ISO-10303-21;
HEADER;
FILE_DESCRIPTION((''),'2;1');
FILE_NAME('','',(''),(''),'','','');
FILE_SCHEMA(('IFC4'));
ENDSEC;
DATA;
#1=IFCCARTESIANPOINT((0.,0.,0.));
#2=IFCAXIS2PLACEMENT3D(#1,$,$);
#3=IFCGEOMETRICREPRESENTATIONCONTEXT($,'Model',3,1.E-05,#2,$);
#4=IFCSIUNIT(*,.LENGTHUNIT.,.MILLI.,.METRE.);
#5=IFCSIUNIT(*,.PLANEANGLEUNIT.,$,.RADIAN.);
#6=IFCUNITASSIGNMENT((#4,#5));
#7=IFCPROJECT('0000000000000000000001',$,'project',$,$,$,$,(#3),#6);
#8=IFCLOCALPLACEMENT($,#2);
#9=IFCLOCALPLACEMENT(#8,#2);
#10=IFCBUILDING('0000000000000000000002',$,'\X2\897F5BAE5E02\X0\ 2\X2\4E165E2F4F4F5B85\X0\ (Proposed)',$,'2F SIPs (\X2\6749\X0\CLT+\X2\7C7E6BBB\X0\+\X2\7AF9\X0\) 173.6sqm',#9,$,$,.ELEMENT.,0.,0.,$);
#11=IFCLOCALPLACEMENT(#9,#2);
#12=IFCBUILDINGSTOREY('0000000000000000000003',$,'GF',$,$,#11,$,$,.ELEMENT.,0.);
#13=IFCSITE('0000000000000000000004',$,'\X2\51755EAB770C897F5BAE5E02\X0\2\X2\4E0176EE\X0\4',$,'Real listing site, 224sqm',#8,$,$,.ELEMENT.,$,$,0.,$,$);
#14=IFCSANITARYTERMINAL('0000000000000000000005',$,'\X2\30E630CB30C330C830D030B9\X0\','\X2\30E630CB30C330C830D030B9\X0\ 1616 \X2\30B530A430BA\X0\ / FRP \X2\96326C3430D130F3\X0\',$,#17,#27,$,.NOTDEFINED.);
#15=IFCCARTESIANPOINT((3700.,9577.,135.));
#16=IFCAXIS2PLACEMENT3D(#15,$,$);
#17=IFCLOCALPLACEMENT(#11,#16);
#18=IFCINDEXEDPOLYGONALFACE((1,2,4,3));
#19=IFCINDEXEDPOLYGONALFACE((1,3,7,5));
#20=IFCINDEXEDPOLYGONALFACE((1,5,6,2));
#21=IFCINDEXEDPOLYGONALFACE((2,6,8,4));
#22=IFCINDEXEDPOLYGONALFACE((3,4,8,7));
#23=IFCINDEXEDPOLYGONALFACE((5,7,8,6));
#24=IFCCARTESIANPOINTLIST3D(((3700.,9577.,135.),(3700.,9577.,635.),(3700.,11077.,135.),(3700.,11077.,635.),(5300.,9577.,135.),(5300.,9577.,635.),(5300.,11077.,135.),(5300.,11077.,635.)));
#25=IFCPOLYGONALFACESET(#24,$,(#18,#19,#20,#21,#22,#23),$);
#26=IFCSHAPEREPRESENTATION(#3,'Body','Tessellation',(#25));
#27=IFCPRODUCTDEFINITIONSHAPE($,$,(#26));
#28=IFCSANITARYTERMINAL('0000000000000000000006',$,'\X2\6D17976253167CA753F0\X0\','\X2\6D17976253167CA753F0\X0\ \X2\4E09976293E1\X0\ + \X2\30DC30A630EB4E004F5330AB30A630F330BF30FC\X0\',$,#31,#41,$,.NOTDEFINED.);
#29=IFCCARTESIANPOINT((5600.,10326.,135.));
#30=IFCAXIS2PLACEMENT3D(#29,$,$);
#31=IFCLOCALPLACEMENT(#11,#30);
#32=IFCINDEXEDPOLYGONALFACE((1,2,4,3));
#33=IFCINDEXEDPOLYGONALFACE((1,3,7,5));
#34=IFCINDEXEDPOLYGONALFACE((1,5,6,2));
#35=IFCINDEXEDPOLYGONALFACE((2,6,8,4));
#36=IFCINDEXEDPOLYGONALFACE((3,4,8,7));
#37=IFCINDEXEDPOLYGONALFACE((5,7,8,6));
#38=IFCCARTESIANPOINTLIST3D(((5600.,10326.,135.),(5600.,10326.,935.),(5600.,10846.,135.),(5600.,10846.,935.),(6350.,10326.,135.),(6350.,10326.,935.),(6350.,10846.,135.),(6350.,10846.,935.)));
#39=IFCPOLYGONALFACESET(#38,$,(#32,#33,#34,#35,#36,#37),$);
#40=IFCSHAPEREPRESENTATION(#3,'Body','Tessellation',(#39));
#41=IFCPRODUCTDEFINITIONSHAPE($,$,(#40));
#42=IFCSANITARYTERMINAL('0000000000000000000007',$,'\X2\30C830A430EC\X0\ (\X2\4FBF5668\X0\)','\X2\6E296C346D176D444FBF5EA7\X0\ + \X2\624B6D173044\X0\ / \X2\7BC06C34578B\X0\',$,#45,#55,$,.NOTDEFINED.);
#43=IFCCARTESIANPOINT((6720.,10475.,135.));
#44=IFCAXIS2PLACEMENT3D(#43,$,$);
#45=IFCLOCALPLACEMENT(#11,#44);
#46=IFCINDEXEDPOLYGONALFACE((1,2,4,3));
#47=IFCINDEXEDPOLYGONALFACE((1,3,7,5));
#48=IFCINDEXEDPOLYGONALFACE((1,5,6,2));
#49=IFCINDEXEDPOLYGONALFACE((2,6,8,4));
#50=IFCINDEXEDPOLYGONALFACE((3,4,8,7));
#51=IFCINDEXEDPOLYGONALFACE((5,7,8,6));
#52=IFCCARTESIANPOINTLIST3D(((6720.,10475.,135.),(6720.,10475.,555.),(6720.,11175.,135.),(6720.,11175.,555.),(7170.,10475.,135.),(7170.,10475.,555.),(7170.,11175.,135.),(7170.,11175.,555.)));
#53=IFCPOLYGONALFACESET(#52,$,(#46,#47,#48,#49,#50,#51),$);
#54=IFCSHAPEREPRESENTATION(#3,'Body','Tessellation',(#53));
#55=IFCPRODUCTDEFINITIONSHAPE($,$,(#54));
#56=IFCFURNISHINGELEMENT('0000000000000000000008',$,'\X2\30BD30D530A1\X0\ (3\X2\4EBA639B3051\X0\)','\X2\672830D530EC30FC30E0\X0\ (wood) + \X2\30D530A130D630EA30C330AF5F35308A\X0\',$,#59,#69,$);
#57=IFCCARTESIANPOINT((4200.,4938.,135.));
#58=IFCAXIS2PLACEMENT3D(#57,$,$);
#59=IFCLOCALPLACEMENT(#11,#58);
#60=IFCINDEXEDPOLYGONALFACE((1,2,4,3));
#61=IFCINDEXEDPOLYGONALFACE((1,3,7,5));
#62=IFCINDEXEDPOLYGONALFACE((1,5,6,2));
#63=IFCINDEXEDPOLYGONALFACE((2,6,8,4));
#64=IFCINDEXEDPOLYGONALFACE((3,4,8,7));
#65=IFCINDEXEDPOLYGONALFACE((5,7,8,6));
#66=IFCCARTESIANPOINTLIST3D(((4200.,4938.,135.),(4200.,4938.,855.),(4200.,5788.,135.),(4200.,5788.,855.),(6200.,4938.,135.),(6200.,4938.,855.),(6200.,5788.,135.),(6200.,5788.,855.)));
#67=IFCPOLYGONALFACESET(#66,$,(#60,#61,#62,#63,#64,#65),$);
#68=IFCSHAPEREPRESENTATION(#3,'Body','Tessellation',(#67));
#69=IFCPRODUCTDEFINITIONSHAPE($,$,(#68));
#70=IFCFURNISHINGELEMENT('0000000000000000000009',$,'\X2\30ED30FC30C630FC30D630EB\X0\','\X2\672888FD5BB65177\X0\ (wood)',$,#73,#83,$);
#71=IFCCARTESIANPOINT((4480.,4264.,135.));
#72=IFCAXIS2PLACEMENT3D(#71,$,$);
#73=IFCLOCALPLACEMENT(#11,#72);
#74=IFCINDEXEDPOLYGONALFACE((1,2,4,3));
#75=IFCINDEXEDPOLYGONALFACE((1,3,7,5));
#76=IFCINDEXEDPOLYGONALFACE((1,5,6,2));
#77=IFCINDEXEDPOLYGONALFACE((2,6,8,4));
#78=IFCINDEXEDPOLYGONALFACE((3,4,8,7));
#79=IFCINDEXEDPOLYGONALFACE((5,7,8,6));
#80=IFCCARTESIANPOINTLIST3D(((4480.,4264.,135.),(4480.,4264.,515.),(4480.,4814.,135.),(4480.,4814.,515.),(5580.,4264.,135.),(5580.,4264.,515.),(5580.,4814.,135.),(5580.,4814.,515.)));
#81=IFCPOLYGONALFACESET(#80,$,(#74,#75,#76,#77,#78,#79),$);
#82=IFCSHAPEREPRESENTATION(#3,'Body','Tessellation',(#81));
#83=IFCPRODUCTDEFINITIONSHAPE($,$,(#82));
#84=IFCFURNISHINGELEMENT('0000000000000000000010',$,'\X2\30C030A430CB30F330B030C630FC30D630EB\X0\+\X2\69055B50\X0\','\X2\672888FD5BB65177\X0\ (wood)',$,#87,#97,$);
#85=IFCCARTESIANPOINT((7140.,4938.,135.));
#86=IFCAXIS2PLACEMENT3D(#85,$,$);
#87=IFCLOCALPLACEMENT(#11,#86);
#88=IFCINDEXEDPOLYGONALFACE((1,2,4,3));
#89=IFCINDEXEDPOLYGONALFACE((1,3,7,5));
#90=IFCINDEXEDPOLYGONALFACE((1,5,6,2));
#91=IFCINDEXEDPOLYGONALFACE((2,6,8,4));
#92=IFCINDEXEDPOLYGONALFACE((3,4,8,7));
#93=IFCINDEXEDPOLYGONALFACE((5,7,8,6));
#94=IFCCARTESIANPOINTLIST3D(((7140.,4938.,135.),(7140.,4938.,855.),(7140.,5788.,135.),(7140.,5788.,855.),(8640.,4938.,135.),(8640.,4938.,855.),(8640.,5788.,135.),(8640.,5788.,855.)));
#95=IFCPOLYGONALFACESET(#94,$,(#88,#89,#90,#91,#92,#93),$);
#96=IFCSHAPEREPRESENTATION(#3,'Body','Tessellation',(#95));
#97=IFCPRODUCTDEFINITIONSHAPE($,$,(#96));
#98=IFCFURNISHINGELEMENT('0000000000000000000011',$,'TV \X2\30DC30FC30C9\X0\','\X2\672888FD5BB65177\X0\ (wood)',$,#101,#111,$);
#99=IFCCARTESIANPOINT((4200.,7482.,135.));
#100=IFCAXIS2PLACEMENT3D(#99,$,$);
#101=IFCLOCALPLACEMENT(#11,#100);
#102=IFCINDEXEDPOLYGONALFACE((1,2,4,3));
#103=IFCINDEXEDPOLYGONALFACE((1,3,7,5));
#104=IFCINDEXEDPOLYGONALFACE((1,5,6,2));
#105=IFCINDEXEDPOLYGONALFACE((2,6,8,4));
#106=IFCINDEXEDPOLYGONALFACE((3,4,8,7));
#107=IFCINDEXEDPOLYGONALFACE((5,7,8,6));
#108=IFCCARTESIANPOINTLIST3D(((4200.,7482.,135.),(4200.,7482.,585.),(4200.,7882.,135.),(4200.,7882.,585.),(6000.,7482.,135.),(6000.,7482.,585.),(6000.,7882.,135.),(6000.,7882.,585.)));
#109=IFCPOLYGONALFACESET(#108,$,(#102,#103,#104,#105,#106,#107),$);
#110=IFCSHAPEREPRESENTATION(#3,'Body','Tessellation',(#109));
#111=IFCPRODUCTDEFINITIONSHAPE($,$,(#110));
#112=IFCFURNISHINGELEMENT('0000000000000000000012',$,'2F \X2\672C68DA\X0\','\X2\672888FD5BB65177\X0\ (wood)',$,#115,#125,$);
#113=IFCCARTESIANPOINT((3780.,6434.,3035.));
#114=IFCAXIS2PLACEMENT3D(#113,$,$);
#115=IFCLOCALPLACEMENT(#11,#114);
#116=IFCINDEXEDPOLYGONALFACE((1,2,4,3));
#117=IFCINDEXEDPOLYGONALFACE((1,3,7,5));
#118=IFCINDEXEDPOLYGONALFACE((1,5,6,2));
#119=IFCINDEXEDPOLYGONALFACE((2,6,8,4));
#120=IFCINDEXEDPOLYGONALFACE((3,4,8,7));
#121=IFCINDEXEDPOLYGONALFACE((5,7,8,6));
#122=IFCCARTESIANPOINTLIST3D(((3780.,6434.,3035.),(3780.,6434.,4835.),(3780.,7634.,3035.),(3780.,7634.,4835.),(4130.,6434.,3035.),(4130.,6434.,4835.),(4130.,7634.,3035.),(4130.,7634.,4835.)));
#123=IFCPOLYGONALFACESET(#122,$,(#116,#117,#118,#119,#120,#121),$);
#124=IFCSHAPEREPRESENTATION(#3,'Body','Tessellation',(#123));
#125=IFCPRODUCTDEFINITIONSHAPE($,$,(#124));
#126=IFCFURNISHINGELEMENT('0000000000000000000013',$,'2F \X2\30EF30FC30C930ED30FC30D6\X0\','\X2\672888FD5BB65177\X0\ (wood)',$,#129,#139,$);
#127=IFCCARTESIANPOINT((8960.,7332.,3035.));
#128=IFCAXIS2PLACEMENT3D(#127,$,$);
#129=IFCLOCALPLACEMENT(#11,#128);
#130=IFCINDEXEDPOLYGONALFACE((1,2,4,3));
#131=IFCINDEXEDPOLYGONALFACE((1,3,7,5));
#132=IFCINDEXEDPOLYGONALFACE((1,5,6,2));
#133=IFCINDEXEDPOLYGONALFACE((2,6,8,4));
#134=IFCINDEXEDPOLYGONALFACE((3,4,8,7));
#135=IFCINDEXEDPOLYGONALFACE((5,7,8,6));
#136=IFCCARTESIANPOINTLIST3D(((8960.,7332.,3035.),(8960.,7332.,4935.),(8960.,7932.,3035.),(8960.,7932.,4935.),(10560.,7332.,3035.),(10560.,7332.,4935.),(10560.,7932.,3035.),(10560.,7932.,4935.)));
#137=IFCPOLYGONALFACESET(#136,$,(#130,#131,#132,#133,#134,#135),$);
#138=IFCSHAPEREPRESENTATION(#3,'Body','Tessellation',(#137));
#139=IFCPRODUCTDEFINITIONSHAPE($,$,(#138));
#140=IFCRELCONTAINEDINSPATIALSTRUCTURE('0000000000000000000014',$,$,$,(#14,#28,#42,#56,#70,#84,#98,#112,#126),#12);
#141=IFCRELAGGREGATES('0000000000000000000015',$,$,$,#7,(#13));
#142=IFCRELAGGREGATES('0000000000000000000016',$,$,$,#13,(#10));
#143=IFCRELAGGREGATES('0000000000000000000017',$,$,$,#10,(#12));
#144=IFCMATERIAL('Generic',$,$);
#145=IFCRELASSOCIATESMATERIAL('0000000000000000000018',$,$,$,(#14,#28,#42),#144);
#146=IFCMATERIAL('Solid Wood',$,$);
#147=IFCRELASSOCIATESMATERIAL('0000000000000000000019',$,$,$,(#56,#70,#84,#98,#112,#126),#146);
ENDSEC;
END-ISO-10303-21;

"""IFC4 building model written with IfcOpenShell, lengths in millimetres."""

from ifc_helpers import new_model, si_unit, frame, frame_2d, origin, place, context, project, spatial, rectangle, extrude, material, element, save


model = new_model("IFC4")

# Units and contexts
model_context = context("Model", 3, precision=1e-05, world=origin())
ifc_project = project(units=[si_unit("LENGTHUNIT", "METRE", prefix="MILLI"), si_unit("PLANEANGLEUNIT", "RADIAN")], contexts=[model_context])

# Site, building, storey
site_placement = place(None, origin())
site = spatial("IfcSite", under=ifc_project, at=site_placement, Name="兵庫県西宮市2丁目4", ObjectType="Real listing site, 224sqm", CompositionType="ELEMENT", RefElevation=0.0)
building_placement = place(site_placement, origin())
building = spatial("IfcBuilding", under=site, at=building_placement, Name="西宮市 2世帯住宅 (Proposed)", ObjectType="2F SIPs (杉CLT+籾殻+竹) 173.6sqm", CompositionType="ELEMENT", ElevationOfRefHeight=0.0, ElevationOfTerrain=0.0)
storey_placement = place(building_placement, origin())
storey = spatial("IfcBuildingStorey", under=building, at=storey_placement, Name="GF", CompositionType="ELEMENT", Elevation=0.0)

# Shared definitions
ifc_material_1 = material(Name="Generic")

# Shared definitions
ifc_material_2 = material(Name="Solid Wood")

# Sanitary terminals
sanitary_terminal_1_placement = place(storey_placement, frame((3700.0, 9577.0, 135.0)))
element("IfcSanitaryTerminal", 1, at=sanitary_terminal_1_placement, inside=storey, material=ifc_material_1, Name="ユニットバス", Description="ユニットバス 1616 サイズ / FRP 防水パン", PredefinedType="NOTDEFINED", context=model_context, shape_type="SweptSolid", body=[
    extrude(rectangle(XDim=1600.0, YDim=1500.0, at=frame_2d((800.0, 750.0))), frame((3700.0, 9577.0, 135.0)), (0.0, 0.0, 1.0), 500.0),
])
sanitary_terminal_2_placement = place(storey_placement, frame((5600.0, 10326.0, 135.0)))
element("IfcSanitaryTerminal", 2, at=sanitary_terminal_2_placement, inside=storey, material=ifc_material_1, Name="洗面化粧台", Description="洗面化粧台 三面鏡 + ボウル一体カウンター", PredefinedType="NOTDEFINED", context=model_context, shape_type="SweptSolid", body=[
    extrude(rectangle(XDim=750.0, YDim=520.0, at=frame_2d((375.0, 260.0))), frame((5600.0, 10326.0, 135.0)), (0.0, 0.0, 1.0), 800.0),
])
sanitary_terminal_3_placement = place(storey_placement, frame((6720.0, 10475.0, 135.0)))
element("IfcSanitaryTerminal", 3, at=sanitary_terminal_3_placement, inside=storey, material=ifc_material_1, Name="トイレ (便器)", Description="温水洗浄便座 + 手洗い / 節水型", PredefinedType="NOTDEFINED", context=model_context, shape_type="SweptSolid", body=[
    extrude(rectangle(XDim=450.0, YDim=700.0, at=frame_2d((225.0, 350.0))), frame((6720.0, 10475.0, 135.0)), (0.0, 0.0, 1.0), 420.0),
])

# Furnishing elements
furnishing_1_placement = place(storey_placement, frame((4200.0, 4938.0, 135.0)))
element("IfcFurnishingElement", 4, at=furnishing_1_placement, inside=storey, material=ifc_material_2, Name="ソファ (3人掛け)", Description="木フレーム (wood) + ファブリック張り", context=model_context, shape_type="SweptSolid", body=[
    extrude(rectangle(XDim=2000.0, YDim=850.0, at=frame_2d((1000.0, 425.0))), frame((4200.0, 4938.0, 135.0)), (0.0, 0.0, 1.0), 720.0),
])
furnishing_2_placement = place(storey_placement, frame((4480.0, 4264.0, 135.0)))
element("IfcFurnishingElement", 5, at=furnishing_2_placement, inside=storey, material=ifc_material_2, Name="ローテーブル", Description="木製家具 (wood)", context=model_context, shape_type="SweptSolid", body=[
    extrude(rectangle(XDim=1100.0, YDim=550.0, at=frame_2d((550.0, 275.0))), frame((4480.0, 4264.0, 135.0)), (0.0, 0.0, 1.0), 380.0),
])
furnishing_3_placement = place(storey_placement, frame((7140.0, 4938.0, 135.0)))
element("IfcFurnishingElement", 6, at=furnishing_3_placement, inside=storey, material=ifc_material_2, Name="ダイニングテーブル+椅子", Description="木製家具 (wood)", context=model_context, shape_type="SweptSolid", body=[
    extrude(rectangle(XDim=1500.0, YDim=850.0, at=frame_2d((750.0, 425.0))), frame((7140.0, 4938.0, 135.0)), (0.0, 0.0, 1.0), 720.0),
])
furnishing_4_placement = place(storey_placement, frame((4200.0, 7482.0, 135.0)))
element("IfcFurnishingElement", 7, at=furnishing_4_placement, inside=storey, material=ifc_material_2, Name="TV ボード", Description="木製家具 (wood)", context=model_context, shape_type="SweptSolid", body=[
    extrude(rectangle(XDim=1800.0, YDim=400.0, at=frame_2d((900.0, 200.0))), frame((4200.0, 7482.0, 135.0)), (0.0, 0.0, 1.0), 450.0),
])
furnishing_5_placement = place(storey_placement, frame((3780.0, 6434.0, 3035.0)))
element("IfcFurnishingElement", 8, at=furnishing_5_placement, inside=storey, material=ifc_material_2, Name="2F 本棚", Description="木製家具 (wood)", context=model_context, shape_type="SweptSolid", body=[
    extrude(rectangle(XDim=350.0, YDim=1200.0, at=frame_2d((175.0, 600.0))), frame((3780.0, 6434.0, 3035.0)), (0.0, 0.0, 1.0), 1800.0),
])
furnishing_6_placement = place(storey_placement, frame((8960.0, 7332.0, 3035.0)))
element("IfcFurnishingElement", 9, at=furnishing_6_placement, inside=storey, material=ifc_material_2, Name="2F ワードローブ", Description="木製家具 (wood)", context=model_context, shape_type="SweptSolid", body=[
    extrude(rectangle(XDim=1600.0, YDim=600.0, at=frame_2d((800.0, 300.0))), frame((8960.0, 7332.0, 3035.0)), (0.0, 0.0, 1.0), 1900.0),
])

save(model, "model.ifc")
